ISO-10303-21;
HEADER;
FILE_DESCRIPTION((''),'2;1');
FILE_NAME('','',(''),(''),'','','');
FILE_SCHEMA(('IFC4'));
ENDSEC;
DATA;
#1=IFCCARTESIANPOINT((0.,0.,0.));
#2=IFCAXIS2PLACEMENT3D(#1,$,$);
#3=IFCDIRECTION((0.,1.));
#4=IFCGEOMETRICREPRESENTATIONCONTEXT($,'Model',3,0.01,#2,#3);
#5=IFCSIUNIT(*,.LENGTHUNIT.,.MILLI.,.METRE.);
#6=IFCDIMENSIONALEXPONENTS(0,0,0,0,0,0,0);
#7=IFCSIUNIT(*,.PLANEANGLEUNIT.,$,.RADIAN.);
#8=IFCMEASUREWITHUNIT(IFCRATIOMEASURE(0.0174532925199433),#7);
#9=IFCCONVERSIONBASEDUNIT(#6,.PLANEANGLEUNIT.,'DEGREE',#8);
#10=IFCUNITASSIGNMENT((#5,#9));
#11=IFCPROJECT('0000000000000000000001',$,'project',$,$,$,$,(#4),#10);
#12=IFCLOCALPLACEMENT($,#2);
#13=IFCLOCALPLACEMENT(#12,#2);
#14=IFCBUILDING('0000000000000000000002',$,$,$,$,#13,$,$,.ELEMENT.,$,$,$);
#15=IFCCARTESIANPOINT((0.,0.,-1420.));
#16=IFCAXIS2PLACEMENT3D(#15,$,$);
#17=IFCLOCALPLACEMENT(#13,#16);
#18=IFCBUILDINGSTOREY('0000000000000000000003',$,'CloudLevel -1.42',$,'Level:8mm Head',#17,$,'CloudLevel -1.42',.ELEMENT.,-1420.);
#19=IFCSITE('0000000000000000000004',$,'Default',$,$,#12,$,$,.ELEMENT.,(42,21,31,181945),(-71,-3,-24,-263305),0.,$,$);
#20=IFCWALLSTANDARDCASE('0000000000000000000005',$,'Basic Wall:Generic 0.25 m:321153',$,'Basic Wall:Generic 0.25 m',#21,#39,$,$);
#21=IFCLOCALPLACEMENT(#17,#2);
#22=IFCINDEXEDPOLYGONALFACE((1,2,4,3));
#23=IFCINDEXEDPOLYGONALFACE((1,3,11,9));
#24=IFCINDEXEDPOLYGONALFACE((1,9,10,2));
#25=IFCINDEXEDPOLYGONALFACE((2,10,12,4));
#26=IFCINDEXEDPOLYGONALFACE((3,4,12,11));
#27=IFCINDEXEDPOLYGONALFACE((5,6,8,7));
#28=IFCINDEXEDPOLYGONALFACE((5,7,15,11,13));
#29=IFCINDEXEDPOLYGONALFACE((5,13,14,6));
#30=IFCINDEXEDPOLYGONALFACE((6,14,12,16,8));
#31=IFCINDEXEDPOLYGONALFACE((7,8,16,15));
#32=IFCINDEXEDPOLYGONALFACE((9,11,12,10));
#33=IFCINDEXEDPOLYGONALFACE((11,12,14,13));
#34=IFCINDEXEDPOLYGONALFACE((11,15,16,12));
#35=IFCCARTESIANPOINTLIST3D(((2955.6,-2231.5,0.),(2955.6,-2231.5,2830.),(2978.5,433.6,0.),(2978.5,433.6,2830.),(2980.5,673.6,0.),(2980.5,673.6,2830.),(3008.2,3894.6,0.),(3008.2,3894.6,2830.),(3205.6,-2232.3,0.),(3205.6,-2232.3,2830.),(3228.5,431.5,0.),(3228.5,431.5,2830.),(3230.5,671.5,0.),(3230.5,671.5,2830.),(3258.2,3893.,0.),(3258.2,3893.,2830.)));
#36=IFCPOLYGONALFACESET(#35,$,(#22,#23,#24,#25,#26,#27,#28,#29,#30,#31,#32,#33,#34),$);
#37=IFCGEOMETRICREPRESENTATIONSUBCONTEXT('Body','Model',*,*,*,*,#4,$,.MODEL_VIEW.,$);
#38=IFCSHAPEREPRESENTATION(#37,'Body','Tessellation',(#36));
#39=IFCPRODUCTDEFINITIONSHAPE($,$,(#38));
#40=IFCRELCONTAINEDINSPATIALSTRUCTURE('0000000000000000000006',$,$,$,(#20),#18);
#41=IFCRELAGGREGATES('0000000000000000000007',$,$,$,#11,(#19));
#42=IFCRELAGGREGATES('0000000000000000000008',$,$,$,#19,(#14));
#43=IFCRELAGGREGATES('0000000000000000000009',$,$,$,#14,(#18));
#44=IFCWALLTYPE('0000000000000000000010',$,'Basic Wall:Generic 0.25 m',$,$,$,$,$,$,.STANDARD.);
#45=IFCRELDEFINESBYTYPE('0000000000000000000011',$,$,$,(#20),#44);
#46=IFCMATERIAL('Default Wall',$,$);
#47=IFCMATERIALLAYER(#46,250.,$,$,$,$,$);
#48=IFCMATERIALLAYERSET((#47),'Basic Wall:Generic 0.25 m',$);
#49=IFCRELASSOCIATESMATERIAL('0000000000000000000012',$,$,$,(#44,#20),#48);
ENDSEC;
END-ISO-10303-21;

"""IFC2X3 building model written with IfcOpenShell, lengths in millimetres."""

from ifc_helpers import new_model, entity, si_unit, converted_unit, direction, frame, frame_2d, origin, place, context, subcontext, project, spatial, polyline, rectangle, outline, extrude, material, layer, layer_set, layer_usage, type_object, element, save


model = new_model("IFC2X3")

# Units and contexts
model_context = context("Model", 3, precision=0.01, world=origin(), true_north=direction((0.0, 1.0)))
body_context = subcontext(model_context, "Body", "Model", "MODEL_VIEW")
ifc_project = project(units=[si_unit("LENGTHUNIT", "METRE", prefix="MILLI"), converted_unit("PLANEANGLEUNIT", "DEGREE", entity("IfcRatioMeasure", 0.0174532925199433), si_unit("PLANEANGLEUNIT", "RADIAN"), dimensions=[0, 0, 0, 0, 0, 0, 0])], contexts=[model_context])

# Site, building, storey
site_placement = place(None, origin())
site = spatial("IfcSite", under=ifc_project, at=site_placement, Name="Default", CompositionType="ELEMENT", RefLatitude=(42, 21, 31, 181945), RefLongitude=(-71, -3, -24, -263305), RefElevation=0.0)
building_placement = place(site_placement, origin())
building = spatial("IfcBuilding", under=site, at=building_placement, CompositionType="ELEMENT")
storey_placement = place(building_placement, frame((0.0, 0.0, -1420.0)))
storey = spatial("IfcBuildingStorey", under=building, at=storey_placement, Name="CloudLevel -1.42", ObjectType="Level:8mm Head", LongName="CloudLevel -1.42", CompositionType="ELEMENT", Elevation=-1420.0)

# Shared definitions
ifc_material_1 = material(Name="Default Wall")

# Wall, opening
ifc_layer_1 = layer(ifc_material_1, 250.0)
ifc_layer_set_1 = layer_set([ifc_layer_1], Name="Basic Wall:Generic 0.25 m")
ifc_layer_usage_1 = layer_usage(ifc_layer_set_1, "AXIS2", "NEGATIVE", 125.0)
wall_type_1 = type_object("IfcWallType", Name="Basic Wall:Generic 0.25 m", PredefinedType="STANDARD", material=ifc_layer_set_1)
wall_1_placement = place(storey_placement, frame((3133.2, 3894.1, 0.0), z_axis=(0.0, 0.0, 1.0), x_axis=(-0.008572, -0.999963, 0.0)))
wall_1 = element("IfcWallStandardCase", 1, at=wall_1_placement, inside=storey, type_object=wall_type_1, material=ifc_layer_usage_1, Name="Basic Wall:Generic 0.25 m:321153", ObjectType="Basic Wall:Generic 0.25 m", context=body_context, shape_type="SweptSolid", body=[
    extrude(outline(polyline([(0.0, 125.0), (0.6, -125.0), (6126.9, -125.0), (6125.6, 125.0), (0.0, 125.0)])), origin(), (0.0, 0.0, 1.0), 2830.0),
])
opening_1_placement = place(storey_placement, frame((3133.2, 3894.1, 0.0), z_axis=(0.0, 0.0, 1.0), x_axis=(-0.008572, -0.999963, 0.0)))
element("IfcOpeningElement", 2, at=opening_1_placement, cuts=wall_1, ObjectType="Opening", context=body_context, shape_type="SweptSolid", body=[
    extrude(rectangle(XDim=2830.0, YDim=250.0, at=frame_2d((0.0, 0.0), x_axis=(1.0, 0.0))), frame((3461.7, 0.0, 1415.0), z_axis=(-1.0, -0.000324, 0.0), x_axis=(0.0, 0.0, 1.0)), (0.0, 0.0, 1.0), 240.0),
])

save(model, "model.ifc")
